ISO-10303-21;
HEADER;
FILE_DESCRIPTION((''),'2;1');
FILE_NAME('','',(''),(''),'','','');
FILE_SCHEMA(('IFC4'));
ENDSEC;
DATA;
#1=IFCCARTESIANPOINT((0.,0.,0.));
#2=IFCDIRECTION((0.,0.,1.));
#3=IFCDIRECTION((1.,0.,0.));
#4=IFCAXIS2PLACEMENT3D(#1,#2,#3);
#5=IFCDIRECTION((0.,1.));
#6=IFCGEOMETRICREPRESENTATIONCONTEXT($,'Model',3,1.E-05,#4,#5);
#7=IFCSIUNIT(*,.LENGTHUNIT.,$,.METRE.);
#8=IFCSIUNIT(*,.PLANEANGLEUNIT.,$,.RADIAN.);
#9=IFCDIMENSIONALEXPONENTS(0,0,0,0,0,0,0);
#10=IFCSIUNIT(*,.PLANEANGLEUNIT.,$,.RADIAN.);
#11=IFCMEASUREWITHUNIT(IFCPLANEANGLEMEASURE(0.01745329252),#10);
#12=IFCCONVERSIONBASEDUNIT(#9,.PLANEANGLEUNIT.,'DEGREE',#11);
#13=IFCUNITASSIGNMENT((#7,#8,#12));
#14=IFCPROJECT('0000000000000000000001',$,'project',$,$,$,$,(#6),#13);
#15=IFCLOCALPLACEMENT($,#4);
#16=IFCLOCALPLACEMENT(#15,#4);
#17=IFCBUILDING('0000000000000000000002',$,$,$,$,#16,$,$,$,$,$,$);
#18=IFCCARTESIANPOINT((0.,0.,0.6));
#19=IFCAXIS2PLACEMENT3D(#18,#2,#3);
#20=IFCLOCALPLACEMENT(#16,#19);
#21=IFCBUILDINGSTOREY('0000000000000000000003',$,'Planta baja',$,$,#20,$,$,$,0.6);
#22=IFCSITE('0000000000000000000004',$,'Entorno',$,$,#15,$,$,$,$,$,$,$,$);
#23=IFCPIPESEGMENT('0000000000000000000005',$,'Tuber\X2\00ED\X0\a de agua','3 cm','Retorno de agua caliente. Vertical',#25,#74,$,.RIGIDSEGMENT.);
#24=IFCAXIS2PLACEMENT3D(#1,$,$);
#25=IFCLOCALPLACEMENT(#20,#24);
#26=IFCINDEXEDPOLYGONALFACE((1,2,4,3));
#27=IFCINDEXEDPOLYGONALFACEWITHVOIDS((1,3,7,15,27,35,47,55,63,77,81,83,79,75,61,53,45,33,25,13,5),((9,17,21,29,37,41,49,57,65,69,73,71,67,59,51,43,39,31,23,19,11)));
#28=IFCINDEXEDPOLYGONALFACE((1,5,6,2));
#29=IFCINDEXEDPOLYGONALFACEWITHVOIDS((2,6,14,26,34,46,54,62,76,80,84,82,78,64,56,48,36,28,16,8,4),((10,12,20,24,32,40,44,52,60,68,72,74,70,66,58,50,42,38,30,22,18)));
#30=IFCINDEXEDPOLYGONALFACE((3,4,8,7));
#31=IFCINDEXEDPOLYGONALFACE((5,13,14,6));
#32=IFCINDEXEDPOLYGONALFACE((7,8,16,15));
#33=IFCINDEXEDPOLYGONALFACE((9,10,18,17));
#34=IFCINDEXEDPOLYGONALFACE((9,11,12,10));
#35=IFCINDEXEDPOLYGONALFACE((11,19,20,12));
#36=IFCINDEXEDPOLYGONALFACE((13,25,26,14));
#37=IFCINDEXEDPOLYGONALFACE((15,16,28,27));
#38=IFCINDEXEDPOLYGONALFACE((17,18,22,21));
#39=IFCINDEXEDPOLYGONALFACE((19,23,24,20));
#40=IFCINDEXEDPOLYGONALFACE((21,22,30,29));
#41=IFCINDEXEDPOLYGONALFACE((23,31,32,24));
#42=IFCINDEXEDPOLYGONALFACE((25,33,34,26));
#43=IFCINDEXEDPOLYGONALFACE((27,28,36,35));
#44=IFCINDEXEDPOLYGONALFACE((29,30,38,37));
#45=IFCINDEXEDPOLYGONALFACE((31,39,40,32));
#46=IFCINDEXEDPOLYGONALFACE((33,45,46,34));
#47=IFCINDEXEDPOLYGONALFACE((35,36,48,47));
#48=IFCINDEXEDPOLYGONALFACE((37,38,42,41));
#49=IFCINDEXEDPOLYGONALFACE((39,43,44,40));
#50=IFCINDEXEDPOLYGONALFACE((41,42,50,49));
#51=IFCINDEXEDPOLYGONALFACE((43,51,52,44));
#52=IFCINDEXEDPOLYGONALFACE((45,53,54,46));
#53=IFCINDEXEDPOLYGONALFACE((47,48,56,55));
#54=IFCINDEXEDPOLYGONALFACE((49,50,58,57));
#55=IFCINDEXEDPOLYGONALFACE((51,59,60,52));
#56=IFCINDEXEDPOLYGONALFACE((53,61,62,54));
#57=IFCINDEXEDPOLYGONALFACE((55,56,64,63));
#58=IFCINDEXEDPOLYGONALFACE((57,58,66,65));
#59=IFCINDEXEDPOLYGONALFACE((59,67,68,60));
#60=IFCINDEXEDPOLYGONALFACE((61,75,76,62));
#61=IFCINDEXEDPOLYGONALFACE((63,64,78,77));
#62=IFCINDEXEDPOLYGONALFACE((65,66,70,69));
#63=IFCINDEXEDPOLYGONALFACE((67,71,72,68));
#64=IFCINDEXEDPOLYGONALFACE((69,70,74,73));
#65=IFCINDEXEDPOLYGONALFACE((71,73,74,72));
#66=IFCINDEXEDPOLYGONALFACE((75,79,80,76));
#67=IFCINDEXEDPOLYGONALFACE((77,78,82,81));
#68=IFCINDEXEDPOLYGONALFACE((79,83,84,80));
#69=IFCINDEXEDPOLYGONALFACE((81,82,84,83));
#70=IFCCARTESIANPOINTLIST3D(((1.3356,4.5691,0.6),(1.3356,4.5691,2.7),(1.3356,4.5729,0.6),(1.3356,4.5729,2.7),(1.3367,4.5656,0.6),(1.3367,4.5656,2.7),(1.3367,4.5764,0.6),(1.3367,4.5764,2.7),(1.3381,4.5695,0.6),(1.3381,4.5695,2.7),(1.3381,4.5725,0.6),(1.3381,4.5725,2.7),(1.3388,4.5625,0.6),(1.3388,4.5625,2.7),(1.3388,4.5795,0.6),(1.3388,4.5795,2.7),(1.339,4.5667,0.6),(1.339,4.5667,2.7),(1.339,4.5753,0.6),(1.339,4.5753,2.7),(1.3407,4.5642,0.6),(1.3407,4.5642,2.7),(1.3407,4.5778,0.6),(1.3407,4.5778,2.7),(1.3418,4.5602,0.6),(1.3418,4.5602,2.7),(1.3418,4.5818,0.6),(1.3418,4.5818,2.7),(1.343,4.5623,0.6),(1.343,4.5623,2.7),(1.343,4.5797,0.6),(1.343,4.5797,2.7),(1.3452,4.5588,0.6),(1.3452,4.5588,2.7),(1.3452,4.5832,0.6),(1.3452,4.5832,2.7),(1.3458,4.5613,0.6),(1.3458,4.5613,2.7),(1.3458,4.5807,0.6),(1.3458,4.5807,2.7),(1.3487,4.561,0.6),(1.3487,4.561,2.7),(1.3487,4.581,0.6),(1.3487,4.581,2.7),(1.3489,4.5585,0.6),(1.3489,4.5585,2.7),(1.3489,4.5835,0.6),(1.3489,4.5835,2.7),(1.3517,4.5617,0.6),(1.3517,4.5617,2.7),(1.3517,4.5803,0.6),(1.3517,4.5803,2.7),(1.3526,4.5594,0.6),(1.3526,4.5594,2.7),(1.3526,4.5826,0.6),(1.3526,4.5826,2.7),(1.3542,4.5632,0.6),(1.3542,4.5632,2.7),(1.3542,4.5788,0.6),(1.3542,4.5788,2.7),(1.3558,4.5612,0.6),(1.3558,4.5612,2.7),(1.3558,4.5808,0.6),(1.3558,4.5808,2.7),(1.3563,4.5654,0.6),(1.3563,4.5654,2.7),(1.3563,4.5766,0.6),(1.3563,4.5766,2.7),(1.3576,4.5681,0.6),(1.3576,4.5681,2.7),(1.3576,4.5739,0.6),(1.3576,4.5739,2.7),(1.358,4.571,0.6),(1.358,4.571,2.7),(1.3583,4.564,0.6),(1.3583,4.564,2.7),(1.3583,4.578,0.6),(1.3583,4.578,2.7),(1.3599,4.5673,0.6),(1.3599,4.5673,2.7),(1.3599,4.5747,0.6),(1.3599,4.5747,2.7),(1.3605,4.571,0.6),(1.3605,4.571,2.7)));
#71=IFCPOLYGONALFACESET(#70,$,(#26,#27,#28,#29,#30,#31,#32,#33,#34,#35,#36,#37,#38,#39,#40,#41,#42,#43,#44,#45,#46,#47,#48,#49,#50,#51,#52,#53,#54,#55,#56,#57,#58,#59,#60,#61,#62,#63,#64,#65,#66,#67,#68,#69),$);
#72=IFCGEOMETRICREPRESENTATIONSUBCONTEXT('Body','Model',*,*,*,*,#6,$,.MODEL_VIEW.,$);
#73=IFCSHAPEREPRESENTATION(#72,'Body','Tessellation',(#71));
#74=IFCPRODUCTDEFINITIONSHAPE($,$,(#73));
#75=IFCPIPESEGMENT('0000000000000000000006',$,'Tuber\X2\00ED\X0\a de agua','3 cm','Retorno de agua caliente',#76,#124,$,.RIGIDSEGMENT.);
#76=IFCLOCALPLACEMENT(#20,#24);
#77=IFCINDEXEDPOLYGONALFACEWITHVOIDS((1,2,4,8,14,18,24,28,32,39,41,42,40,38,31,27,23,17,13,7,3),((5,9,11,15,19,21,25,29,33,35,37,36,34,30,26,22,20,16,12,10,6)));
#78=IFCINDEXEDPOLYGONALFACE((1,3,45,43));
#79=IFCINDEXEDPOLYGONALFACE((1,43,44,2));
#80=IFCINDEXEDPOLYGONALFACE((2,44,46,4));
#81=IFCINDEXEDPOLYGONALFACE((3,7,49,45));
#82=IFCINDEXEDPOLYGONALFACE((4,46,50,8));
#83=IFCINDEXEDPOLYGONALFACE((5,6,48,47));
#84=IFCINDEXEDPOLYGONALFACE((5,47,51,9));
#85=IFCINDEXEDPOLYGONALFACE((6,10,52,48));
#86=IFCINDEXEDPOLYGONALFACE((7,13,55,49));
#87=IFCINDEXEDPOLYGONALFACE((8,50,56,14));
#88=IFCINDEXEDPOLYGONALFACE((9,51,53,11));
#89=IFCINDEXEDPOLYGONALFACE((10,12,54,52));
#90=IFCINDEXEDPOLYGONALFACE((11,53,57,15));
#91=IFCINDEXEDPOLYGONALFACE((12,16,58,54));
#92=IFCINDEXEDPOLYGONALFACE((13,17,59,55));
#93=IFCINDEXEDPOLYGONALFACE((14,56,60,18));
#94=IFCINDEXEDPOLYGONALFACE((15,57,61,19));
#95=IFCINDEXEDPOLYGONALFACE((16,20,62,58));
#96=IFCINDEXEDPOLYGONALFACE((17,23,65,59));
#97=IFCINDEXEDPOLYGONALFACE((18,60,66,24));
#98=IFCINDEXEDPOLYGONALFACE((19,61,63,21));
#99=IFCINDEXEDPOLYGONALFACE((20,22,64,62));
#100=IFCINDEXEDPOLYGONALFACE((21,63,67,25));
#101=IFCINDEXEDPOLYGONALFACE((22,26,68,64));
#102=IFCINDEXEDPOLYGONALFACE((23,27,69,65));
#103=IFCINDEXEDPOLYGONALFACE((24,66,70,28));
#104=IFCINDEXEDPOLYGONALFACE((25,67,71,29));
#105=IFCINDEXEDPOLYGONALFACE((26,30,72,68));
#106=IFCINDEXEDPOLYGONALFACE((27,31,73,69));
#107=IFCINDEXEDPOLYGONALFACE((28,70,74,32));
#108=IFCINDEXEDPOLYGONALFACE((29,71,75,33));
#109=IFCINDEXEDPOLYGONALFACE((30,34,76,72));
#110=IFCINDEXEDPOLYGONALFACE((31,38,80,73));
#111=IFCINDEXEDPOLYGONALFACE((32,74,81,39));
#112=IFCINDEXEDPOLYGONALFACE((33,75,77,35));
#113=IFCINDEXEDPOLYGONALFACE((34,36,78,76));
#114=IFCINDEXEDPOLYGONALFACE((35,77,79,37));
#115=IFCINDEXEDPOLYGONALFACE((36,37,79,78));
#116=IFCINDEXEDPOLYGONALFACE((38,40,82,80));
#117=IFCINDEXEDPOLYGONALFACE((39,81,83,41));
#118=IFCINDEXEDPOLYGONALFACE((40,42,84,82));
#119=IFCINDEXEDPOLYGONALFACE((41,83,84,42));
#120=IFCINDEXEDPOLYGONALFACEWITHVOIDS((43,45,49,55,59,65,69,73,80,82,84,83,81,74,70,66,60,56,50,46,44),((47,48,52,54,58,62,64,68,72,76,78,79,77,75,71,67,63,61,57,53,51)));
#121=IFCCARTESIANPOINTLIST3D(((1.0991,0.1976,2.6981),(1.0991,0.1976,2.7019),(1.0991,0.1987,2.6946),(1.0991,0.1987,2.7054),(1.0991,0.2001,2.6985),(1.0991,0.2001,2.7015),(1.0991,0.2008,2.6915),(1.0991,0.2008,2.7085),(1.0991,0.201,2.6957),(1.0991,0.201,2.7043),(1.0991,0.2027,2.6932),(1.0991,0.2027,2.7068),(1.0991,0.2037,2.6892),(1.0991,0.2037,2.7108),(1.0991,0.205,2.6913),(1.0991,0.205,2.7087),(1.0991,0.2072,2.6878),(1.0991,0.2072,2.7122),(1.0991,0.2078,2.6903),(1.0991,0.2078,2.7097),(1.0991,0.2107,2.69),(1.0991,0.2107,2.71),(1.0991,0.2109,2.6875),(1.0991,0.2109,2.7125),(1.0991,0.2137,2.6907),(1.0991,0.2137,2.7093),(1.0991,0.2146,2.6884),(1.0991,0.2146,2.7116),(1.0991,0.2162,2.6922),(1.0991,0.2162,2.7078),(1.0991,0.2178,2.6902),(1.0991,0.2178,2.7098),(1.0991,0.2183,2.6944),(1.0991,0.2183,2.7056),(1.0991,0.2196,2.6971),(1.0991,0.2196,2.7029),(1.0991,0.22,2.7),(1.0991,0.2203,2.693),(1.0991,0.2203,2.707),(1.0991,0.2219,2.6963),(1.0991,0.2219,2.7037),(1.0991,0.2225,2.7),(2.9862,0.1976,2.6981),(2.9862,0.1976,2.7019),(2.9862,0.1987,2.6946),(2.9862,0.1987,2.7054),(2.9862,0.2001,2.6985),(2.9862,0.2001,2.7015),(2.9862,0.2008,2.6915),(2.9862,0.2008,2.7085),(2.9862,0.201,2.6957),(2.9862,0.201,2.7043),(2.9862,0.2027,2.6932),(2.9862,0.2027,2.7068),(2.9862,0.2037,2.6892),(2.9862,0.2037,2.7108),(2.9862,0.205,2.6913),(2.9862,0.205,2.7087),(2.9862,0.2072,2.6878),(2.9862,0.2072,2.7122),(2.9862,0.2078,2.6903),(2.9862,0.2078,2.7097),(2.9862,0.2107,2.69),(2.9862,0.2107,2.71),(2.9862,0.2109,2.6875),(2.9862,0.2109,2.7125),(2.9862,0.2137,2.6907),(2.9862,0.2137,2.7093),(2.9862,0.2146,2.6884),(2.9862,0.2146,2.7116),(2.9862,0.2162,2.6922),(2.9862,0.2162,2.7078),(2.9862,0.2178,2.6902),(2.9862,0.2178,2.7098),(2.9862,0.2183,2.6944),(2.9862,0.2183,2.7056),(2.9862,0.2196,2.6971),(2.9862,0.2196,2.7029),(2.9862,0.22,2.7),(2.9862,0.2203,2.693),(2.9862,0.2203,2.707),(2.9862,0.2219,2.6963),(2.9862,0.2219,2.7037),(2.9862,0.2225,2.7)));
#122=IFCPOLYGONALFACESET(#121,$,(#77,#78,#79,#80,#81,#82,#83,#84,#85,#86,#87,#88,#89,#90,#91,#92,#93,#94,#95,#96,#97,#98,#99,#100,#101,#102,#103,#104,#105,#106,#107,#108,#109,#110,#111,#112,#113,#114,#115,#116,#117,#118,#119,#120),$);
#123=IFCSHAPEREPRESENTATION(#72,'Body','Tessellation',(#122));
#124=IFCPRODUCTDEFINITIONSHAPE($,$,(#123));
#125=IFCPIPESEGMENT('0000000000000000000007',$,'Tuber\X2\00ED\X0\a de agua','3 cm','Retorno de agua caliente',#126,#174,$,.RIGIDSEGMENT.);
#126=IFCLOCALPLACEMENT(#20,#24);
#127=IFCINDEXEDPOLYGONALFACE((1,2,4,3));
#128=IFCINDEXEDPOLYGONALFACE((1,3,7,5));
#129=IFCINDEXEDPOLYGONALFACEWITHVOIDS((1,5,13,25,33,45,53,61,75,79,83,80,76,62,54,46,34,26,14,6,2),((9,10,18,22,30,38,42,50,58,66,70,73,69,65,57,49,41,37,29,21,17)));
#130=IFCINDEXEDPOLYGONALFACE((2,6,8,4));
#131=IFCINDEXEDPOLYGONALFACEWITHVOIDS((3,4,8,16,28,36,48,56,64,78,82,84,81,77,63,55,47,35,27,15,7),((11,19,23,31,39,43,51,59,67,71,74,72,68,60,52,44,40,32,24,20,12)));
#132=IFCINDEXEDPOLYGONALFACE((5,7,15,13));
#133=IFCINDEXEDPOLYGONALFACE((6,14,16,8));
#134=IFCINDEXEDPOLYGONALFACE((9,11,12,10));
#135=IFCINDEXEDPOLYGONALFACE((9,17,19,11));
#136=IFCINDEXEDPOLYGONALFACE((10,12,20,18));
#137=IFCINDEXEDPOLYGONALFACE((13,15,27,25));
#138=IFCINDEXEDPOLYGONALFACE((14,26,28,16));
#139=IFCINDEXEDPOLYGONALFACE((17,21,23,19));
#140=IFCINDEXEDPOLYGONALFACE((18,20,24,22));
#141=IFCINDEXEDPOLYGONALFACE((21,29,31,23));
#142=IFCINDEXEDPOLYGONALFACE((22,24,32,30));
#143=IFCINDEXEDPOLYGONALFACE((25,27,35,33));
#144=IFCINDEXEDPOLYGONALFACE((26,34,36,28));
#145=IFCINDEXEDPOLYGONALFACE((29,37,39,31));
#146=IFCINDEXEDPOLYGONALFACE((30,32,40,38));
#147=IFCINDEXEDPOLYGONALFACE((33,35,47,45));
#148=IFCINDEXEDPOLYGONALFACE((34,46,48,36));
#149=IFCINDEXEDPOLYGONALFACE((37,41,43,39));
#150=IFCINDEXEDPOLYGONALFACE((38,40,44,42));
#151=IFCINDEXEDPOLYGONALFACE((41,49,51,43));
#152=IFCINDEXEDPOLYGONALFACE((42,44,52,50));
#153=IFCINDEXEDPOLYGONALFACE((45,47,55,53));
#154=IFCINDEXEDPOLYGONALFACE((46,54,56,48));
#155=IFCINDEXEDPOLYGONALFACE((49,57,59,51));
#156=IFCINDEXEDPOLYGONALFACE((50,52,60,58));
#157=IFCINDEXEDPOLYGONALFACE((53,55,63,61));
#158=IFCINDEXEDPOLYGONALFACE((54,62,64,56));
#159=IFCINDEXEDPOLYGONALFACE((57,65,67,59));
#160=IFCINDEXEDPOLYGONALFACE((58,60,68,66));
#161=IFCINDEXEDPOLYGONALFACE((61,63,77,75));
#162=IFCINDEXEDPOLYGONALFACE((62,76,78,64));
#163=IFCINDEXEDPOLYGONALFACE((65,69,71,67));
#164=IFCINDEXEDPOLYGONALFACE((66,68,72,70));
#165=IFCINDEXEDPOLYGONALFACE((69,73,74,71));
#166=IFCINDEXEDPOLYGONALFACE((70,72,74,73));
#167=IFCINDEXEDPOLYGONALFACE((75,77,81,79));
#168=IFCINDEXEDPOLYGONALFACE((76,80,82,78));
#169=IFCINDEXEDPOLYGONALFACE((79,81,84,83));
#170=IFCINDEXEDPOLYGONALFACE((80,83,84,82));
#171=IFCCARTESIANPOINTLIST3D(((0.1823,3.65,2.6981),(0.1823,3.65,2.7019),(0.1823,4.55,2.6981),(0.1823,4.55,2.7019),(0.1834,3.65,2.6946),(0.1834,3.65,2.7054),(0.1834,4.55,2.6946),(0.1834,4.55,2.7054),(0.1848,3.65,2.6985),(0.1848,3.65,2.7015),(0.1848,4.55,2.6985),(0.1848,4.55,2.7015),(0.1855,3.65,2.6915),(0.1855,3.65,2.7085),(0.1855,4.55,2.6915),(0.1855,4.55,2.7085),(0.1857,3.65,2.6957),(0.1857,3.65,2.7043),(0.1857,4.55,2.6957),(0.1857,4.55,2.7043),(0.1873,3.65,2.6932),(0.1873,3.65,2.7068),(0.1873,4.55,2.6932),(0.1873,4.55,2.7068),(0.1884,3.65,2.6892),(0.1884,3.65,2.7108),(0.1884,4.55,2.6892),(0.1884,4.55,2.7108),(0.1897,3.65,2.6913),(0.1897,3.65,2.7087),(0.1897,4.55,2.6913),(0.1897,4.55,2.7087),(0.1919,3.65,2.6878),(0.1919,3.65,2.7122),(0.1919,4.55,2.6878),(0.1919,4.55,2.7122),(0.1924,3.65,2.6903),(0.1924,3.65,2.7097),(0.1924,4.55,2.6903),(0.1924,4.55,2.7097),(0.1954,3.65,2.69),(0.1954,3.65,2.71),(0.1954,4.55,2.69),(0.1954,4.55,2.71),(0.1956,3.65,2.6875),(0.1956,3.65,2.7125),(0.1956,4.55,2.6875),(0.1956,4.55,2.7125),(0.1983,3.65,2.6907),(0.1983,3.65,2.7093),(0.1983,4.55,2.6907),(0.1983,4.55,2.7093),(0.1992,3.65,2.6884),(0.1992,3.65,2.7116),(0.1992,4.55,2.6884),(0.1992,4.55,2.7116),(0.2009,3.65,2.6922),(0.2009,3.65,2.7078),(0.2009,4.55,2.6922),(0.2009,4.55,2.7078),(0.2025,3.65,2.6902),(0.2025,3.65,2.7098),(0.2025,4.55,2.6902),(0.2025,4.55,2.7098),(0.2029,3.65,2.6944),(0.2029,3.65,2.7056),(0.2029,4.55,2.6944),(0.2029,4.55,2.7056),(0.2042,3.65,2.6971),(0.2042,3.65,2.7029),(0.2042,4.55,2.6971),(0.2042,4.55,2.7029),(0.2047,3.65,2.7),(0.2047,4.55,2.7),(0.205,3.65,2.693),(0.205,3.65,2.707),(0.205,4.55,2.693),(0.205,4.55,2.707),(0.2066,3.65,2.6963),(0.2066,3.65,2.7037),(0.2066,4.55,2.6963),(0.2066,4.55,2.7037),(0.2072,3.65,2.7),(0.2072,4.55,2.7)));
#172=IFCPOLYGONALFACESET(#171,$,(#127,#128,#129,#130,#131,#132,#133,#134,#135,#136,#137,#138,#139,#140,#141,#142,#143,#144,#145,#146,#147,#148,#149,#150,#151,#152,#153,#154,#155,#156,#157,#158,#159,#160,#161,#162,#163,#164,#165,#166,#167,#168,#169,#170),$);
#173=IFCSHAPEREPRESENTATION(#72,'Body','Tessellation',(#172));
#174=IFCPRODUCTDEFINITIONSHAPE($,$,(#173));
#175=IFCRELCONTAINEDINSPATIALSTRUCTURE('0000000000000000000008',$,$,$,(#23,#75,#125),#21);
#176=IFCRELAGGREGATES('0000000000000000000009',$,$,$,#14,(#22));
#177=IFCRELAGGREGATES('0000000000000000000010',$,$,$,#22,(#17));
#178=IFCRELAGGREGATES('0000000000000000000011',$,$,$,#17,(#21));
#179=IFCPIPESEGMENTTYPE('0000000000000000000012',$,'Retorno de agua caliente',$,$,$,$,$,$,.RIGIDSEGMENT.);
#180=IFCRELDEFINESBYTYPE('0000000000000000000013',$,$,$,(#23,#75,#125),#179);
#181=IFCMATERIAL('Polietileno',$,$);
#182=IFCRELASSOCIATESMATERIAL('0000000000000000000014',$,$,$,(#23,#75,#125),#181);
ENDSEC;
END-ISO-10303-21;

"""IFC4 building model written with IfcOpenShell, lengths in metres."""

from ifc_helpers import new_model, entity, si_unit, converted_unit, direction, frame, origin_with_axes, origin_2d_with_axis, place, context, subcontext, project, spatial, hollow_circle, extrude, material, type_object, element, save


model = new_model("IFC4")

# Units and contexts
model_context = context("Model", 3, precision=1e-05, world=origin_with_axes(), true_north=direction((0.0, 1.0)))
body_context = subcontext(model_context, "Body", "Model", "MODEL_VIEW")
ifc_project = project(units=[si_unit("LENGTHUNIT", "METRE"), si_unit("PLANEANGLEUNIT", "RADIAN"), converted_unit("PLANEANGLEUNIT", "DEGREE", entity("IfcPlaneAngleMeasure", 0.01745329252), si_unit("PLANEANGLEUNIT", "RADIAN"), dimensions=[0, 0, 0, 0, 0, 0, 0])], contexts=[model_context])

# Site, building, storey
site_placement = place(None, origin_with_axes())
site = spatial("IfcSite", under=ifc_project, at=site_placement, Name="Entorno")
building_placement = place(site_placement, origin_with_axes())
building = spatial("IfcBuilding", under=site, at=building_placement)
storey_placement = place(building_placement, frame((0.0, 0.0, 0.6), z_axis=(0.0, 0.0, 1.0), x_axis=(1.0, 0.0, 0.0)))
storey = spatial("IfcBuildingStorey", under=building, at=storey_placement, Name="Planta baja", Elevation=0.6)

# Pipe segments
ifc_material_1 = material(Name="Polietileno")
pipe_segment_type_1 = type_object("IfcPipeSegmentType", Name="Retorno de agua caliente", PredefinedType="RIGIDSEGMENT")
pipe_segment_1_placement = place(storey_placement, frame((1.348, 4.571, 2.7), z_axis=(0.0, 0.0, -1.0), x_axis=(1.0, 0.0, 0.0)))
element("IfcPipeSegment", 1, at=pipe_segment_1_placement, inside=storey, type_object=pipe_segment_type_1, material=ifc_material_1, Name="Tubería de agua", Description="3 cm", ObjectType="Retorno de agua caliente. Vertical", PredefinedType="RIGIDSEGMENT", context=body_context, shape_type="SweptSolid", body=[
    extrude(hollow_circle(Radius=0.0125, WallThickness=0.0025, at=origin_2d_with_axis()), origin_with_axes(), (0.0, 0.0, 1.0), 2.1),
])
pipe_segment_2_placement = place(storey_placement, frame((1.0991, 0.21, 2.7), z_axis=(1.0, 0.0, 0.0), x_axis=(0.0, 1.0, 0.0)))
element("IfcPipeSegment", 2, at=pipe_segment_2_placement, inside=storey, type_object=pipe_segment_type_1, material=ifc_material_1, Name="Tubería de agua", Description="3 cm", ObjectType="Retorno de agua caliente", PredefinedType="RIGIDSEGMENT", context=body_context, shape_type="SweptSolid", body=[
    extrude(hollow_circle(Radius=0.0125, WallThickness=0.0025, at=origin_2d_with_axis()), origin_with_axes(), (0.0, 0.0, 1.0), 1.8871),
])
pipe_segment_3_placement = place(storey_placement, frame((0.1947, 4.55, 2.7), z_axis=(0.0, -1.0, 0.0), x_axis=(1.0, 0.0, 0.0)))
element("IfcPipeSegment", 3, at=pipe_segment_3_placement, inside=storey, type_object=pipe_segment_type_1, material=ifc_material_1, Name="Tubería de agua", Description="3 cm", ObjectType="Retorno de agua caliente", PredefinedType="RIGIDSEGMENT", context=body_context, shape_type="SweptSolid", body=[
    extrude(hollow_circle(Radius=0.0125, WallThickness=0.0025, at=origin_2d_with_axis()), origin_with_axes(), (0.0, 0.0, 1.0), 0.9),
])

save(model, "model.ifc")
